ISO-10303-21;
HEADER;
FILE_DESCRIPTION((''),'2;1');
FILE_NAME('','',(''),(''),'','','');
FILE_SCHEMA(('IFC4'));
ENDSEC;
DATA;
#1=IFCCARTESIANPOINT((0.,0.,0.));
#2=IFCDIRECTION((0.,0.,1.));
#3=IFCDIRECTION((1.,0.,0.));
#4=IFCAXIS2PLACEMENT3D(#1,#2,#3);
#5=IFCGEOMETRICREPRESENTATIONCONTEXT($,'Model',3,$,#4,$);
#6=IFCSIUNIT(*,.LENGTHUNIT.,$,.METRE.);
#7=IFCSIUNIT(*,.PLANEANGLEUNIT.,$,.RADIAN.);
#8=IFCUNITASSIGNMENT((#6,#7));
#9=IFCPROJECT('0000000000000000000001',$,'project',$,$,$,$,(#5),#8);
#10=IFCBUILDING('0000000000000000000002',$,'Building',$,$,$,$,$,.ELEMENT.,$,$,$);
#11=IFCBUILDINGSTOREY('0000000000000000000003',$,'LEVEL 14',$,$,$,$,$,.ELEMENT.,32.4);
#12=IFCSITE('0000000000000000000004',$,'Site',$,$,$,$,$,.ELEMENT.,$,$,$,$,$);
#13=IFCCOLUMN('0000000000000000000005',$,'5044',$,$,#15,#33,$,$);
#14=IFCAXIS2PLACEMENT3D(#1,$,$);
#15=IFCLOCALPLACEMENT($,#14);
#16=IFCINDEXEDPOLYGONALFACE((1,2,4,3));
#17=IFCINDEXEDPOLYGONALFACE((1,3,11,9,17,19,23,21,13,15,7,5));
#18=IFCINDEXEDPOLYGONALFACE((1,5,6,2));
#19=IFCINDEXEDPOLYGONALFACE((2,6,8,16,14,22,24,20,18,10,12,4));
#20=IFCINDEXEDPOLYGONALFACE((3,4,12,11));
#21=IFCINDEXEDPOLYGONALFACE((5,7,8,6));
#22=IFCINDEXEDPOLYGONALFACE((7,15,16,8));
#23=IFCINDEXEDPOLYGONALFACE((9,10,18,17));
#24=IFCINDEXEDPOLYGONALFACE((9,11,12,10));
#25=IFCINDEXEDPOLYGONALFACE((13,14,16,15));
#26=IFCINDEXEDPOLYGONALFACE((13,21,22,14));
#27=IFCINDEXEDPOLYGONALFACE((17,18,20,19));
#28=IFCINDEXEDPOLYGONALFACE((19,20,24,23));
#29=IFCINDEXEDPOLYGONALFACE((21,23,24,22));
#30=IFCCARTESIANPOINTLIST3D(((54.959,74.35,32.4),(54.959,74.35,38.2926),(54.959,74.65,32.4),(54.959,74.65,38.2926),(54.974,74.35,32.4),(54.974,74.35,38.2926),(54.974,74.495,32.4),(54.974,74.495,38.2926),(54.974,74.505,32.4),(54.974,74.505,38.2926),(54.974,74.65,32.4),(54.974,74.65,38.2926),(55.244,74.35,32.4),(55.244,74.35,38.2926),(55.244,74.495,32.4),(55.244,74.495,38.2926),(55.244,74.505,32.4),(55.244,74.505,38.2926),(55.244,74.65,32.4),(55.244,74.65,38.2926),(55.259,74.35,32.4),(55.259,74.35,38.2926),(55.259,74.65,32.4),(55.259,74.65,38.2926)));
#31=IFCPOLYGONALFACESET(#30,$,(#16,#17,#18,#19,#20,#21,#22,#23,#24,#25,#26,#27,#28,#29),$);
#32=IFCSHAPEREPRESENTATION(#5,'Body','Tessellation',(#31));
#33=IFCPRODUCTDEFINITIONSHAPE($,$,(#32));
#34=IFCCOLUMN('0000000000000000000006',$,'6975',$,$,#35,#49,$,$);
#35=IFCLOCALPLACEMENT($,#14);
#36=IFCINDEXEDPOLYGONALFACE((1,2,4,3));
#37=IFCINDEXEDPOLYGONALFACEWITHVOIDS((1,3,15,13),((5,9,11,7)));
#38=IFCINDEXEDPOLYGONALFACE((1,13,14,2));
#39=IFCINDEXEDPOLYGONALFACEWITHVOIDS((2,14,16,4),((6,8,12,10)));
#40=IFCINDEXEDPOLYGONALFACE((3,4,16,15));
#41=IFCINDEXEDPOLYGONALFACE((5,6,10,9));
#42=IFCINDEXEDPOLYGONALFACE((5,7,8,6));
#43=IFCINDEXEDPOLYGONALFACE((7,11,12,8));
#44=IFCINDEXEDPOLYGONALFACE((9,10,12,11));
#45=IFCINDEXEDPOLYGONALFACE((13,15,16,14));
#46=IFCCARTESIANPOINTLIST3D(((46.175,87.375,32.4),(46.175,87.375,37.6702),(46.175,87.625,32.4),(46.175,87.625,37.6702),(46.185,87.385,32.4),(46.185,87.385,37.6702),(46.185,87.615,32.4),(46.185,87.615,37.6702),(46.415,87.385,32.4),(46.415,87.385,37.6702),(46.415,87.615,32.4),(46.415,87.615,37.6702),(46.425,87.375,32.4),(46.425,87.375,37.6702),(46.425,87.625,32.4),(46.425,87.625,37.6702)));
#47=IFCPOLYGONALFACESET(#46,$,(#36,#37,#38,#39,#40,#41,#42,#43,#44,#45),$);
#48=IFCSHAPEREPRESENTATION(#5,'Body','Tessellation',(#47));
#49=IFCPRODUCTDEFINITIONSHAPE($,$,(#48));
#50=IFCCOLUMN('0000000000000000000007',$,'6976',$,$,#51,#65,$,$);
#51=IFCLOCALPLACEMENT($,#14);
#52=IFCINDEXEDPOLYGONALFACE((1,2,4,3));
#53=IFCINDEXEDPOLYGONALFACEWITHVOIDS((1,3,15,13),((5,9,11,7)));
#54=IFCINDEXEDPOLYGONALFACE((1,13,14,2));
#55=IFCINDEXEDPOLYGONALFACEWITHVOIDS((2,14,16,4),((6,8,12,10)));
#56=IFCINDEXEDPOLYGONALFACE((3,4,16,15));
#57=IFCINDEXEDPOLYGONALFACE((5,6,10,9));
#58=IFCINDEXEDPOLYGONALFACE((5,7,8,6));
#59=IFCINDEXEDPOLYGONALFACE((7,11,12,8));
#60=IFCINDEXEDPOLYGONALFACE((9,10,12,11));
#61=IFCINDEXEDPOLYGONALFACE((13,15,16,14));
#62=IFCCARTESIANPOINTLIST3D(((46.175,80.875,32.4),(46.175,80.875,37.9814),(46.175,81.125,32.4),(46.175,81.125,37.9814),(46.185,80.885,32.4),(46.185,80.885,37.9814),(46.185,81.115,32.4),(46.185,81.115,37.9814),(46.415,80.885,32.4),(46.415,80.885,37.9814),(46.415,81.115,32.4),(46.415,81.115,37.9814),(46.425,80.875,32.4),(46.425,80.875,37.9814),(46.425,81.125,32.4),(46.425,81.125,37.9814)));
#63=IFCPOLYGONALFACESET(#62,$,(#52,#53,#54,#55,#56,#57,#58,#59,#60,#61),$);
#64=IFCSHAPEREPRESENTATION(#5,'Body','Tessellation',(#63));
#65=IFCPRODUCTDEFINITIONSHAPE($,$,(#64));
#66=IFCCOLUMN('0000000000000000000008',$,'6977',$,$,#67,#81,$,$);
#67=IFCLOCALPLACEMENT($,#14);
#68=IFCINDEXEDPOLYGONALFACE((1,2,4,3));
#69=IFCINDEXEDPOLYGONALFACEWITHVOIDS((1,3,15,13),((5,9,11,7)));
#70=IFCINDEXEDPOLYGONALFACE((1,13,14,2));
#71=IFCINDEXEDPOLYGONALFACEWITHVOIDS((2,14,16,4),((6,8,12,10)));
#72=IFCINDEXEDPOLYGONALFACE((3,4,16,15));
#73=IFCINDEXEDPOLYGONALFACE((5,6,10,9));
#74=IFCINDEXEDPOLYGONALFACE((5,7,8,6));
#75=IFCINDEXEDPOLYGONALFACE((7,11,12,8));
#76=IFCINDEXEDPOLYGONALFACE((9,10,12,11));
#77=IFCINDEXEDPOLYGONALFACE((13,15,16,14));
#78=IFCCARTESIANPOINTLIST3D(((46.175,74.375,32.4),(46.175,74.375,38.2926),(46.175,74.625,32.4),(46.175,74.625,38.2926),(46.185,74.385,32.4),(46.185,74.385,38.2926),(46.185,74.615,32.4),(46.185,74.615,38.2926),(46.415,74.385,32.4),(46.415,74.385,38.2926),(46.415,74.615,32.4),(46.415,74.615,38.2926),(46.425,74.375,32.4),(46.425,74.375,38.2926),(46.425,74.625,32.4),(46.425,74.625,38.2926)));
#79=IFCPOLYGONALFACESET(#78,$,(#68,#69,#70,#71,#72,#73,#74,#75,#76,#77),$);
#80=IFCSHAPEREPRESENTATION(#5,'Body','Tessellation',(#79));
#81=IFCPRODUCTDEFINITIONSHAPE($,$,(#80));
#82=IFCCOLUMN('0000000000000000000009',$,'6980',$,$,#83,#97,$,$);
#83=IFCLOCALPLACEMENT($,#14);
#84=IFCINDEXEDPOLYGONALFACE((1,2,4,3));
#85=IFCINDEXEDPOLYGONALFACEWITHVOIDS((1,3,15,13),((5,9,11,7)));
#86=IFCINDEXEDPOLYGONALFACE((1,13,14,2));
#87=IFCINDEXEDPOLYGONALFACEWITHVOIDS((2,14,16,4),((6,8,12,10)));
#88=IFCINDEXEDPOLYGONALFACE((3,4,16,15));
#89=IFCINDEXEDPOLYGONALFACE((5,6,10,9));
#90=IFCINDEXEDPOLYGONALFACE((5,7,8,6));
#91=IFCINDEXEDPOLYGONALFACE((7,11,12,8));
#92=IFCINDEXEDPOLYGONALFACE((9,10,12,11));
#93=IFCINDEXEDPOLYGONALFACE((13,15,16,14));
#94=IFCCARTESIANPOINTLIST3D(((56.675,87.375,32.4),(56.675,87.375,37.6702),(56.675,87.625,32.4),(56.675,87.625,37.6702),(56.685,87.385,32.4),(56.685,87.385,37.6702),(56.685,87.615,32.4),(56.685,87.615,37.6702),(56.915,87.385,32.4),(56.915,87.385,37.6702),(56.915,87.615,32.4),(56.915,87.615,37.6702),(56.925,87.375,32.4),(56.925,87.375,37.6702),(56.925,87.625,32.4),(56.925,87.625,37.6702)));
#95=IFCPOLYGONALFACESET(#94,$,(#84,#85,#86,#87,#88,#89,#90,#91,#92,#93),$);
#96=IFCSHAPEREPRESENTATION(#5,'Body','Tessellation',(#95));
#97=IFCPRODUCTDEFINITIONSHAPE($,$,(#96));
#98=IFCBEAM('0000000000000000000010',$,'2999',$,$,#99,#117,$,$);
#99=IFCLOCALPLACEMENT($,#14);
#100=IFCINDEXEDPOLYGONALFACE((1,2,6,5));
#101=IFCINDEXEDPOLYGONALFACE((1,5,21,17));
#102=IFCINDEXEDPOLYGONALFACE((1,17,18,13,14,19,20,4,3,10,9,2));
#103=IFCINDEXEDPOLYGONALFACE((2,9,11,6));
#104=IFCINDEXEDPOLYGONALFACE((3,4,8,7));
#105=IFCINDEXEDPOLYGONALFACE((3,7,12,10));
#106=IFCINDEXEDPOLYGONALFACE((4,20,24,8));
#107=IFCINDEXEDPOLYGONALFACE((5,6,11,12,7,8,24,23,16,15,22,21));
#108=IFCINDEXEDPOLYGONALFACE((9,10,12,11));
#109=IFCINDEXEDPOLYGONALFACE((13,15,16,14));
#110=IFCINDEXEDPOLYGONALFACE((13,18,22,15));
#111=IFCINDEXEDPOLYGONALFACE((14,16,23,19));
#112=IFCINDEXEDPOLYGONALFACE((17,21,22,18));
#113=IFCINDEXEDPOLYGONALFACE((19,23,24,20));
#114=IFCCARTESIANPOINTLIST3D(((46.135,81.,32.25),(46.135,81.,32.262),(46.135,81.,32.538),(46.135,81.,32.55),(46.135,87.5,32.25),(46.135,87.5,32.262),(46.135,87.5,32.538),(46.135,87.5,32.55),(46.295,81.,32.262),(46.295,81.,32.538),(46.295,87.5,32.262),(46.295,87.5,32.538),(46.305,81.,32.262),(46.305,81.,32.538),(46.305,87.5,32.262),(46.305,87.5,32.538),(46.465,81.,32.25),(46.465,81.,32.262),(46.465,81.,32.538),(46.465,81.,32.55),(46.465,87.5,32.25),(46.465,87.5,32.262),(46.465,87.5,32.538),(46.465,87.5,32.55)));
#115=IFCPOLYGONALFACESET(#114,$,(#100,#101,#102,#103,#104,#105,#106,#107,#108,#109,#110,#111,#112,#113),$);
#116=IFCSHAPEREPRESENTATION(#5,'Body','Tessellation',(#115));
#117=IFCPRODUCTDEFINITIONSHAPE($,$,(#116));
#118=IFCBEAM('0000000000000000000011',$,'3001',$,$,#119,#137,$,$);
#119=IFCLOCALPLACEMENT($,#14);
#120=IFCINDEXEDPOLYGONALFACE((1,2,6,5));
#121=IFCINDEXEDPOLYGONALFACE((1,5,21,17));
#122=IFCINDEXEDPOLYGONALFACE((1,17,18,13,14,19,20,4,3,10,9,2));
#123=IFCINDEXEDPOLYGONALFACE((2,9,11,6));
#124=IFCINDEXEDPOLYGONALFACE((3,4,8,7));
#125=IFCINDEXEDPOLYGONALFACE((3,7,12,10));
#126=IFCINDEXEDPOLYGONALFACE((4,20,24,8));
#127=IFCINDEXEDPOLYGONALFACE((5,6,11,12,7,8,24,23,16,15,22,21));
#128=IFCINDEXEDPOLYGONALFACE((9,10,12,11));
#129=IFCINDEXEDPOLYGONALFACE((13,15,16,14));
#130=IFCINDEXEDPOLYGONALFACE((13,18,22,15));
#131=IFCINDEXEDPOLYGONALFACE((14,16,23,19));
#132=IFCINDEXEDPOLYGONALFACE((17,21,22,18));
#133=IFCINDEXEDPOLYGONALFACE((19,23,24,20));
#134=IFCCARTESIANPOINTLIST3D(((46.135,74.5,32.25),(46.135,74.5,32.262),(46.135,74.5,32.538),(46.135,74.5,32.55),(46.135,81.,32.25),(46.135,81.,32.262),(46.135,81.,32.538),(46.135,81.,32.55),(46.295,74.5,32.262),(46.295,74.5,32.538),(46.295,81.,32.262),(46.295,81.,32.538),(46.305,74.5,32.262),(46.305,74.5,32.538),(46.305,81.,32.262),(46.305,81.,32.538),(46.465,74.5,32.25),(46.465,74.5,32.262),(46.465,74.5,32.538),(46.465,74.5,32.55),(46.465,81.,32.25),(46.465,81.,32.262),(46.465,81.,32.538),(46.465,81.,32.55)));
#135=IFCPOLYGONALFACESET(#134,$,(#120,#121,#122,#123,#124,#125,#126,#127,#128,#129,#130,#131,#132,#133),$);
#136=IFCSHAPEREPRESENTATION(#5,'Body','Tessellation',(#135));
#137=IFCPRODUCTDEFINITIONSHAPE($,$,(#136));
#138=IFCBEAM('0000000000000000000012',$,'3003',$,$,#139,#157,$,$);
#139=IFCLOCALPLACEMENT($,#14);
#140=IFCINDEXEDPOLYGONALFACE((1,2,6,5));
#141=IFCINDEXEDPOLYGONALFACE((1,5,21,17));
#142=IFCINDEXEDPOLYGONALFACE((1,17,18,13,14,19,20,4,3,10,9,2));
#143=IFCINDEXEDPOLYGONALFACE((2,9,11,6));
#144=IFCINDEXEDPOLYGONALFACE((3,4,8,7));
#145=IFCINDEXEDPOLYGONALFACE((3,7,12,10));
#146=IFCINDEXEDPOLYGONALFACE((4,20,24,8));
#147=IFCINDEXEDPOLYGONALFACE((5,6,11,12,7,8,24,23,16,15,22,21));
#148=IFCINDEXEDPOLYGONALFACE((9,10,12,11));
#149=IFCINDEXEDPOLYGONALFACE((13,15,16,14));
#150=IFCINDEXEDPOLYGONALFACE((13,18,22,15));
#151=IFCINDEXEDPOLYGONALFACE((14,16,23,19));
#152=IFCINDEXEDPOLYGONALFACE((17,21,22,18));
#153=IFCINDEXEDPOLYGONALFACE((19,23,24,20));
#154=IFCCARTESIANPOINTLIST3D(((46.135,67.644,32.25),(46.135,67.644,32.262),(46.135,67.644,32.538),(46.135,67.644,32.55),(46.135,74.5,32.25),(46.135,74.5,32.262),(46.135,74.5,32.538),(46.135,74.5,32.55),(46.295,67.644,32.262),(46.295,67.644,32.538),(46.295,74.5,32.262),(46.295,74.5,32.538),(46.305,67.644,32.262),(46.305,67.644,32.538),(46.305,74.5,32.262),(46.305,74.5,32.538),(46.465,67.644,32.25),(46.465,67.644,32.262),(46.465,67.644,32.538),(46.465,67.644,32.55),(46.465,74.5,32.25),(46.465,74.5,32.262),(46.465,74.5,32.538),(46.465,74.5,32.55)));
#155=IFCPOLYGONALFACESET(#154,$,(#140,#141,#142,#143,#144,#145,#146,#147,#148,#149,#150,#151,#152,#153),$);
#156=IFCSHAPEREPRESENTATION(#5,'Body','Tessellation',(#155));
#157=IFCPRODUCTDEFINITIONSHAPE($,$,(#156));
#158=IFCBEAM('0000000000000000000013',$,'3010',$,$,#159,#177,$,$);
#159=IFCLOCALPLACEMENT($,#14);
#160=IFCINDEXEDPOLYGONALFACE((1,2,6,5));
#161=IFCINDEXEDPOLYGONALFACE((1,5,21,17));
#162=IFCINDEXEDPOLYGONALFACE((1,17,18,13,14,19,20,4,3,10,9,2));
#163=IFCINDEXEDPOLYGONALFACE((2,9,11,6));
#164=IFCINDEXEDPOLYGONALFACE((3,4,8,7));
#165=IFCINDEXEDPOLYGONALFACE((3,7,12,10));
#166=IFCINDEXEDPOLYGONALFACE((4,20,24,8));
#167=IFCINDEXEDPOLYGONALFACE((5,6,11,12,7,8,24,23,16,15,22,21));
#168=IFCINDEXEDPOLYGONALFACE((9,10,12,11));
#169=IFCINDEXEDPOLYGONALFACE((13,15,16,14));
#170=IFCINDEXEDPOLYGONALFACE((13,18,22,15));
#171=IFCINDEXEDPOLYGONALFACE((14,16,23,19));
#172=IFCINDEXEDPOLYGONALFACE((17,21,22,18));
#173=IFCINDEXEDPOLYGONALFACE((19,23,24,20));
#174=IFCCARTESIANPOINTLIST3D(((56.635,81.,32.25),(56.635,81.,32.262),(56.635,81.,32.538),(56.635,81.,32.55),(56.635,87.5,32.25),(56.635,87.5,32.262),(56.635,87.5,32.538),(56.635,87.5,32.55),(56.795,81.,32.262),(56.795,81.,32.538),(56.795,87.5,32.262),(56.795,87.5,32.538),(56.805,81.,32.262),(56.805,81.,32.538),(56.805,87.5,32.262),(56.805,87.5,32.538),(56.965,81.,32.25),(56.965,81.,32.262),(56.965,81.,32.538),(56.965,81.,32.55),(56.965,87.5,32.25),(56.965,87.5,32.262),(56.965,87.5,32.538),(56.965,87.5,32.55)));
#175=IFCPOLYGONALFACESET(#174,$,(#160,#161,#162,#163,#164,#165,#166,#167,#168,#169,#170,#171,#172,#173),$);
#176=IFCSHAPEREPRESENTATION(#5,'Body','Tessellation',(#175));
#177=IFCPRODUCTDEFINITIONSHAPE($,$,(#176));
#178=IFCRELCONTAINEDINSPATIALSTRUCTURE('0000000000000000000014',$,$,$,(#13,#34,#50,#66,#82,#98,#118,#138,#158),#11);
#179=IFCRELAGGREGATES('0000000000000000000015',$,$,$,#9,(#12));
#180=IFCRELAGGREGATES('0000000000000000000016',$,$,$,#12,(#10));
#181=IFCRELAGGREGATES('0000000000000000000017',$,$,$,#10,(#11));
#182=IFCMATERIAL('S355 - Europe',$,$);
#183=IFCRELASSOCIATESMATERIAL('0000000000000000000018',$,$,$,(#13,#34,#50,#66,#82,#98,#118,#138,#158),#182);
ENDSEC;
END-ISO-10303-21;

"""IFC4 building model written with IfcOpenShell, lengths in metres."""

from ifc_helpers import new_model, si_unit, frame, origin_with_axes, origin_2d_with_axis, place, context, project, spatial, hollow_rectangle, i_section, extrude, material, material_profile, profile_set, profile_usage, element, save


model = new_model("IFC4")

# Units and contexts
model_context = context("Model", 3, world=origin_with_axes())
ifc_project = project(units=[si_unit("LENGTHUNIT", "METRE"), si_unit("PLANEANGLEUNIT", "RADIAN")], contexts=[model_context])

# Site, building, storey
site = spatial("IfcSite", under=ifc_project, Name="Site", CompositionType="ELEMENT")
building = spatial("IfcBuilding", under=site, Name="Building", CompositionType="ELEMENT")
storey = spatial("IfcBuildingStorey", under=building, Name="LEVEL 14", CompositionType="ELEMENT", Elevation=32.4)

# Columns
ifc_material = material(Name="S355 - Europe")
ifc_material_profile_1 = material_profile(ifc_material, i_section(OverallWidth=0.3, OverallDepth=0.3, WebThickness=0.01, FlangeThickness=0.015, at=origin_2d_with_axis()))
ifc_profile_set_1 = profile_set([ifc_material_profile_1])
ifc_profile_usage_1 = profile_usage(ifc_profile_set_1, cardinal=10)
column_1_placement = place(None, frame((55.109, 74.5, 32.4), z_axis=(0.0, 0.0, 1.0), x_axis=(0.0, -1.0, 0.0)))
element("IfcColumn", 1, at=column_1_placement, inside=storey, material=ifc_profile_usage_1, Name="5044", context=model_context, shape_type="SweptSolid", body=[
    extrude(i_section(OverallWidth=0.3, OverallDepth=0.3, WebThickness=0.01, FlangeThickness=0.015, at=origin_2d_with_axis()), origin_with_axes(), (0.0, 0.0, 1.0), 5.8926),
])
ifc_material_profile_2 = material_profile(ifc_material, hollow_rectangle(XDim=0.25, YDim=0.25, WallThickness=0.01, at=origin_2d_with_axis()))
ifc_profile_set_2 = profile_set([ifc_material_profile_2])
ifc_profile_usage_2 = profile_usage(ifc_profile_set_2, cardinal=10)
column_2_placement = place(None, frame((46.3, 87.5, 32.4), z_axis=(0.0, 0.0, 1.0), x_axis=(0.0, -1.0, 0.0)))
element("IfcColumn", 2, at=column_2_placement, inside=storey, material=ifc_profile_usage_2, Name="6975", context=model_context, shape_type="SweptSolid", body=[
    extrude(hollow_rectangle(XDim=0.25, YDim=0.25, WallThickness=0.01, at=origin_2d_with_axis()), origin_with_axes(), (0.0, 0.0, 1.0), 5.2702),
])
ifc_material_profile_3 = material_profile(ifc_material, hollow_rectangle(XDim=0.25, YDim=0.25, WallThickness=0.01, at=origin_2d_with_axis()))
ifc_profile_set_3 = profile_set([ifc_material_profile_3])
ifc_profile_usage_3 = profile_usage(ifc_profile_set_3, cardinal=10)
column_3_placement = place(None, frame((46.3, 81.0, 32.4), z_axis=(0.0, 0.0, 1.0), x_axis=(0.0, -1.0, 0.0)))
element("IfcColumn", 3, at=column_3_placement, inside=storey, material=ifc_profile_usage_3, Name="6976", context=model_context, shape_type="SweptSolid", body=[
    extrude(hollow_rectangle(XDim=0.25, YDim=0.25, WallThickness=0.01, at=origin_2d_with_axis()), origin_with_axes(), (0.0, 0.0, 1.0), 5.5814),
])
ifc_material_profile_4 = material_profile(ifc_material, hollow_rectangle(XDim=0.25, YDim=0.25, WallThickness=0.01, at=origin_2d_with_axis()))
ifc_profile_set_4 = profile_set([ifc_material_profile_4])
ifc_profile_usage_4 = profile_usage(ifc_profile_set_4, cardinal=10)
column_4_placement = place(None, frame((46.3, 74.5, 32.4), z_axis=(0.0, 0.0, 1.0), x_axis=(0.0, -1.0, 0.0)))
element("IfcColumn", 4, at=column_4_placement, inside=storey, material=ifc_profile_usage_4, Name="6977", context=model_context, shape_type="SweptSolid", body=[
    extrude(hollow_rectangle(XDim=0.25, YDim=0.25, WallThickness=0.01, at=origin_2d_with_axis()), origin_with_axes(), (0.0, 0.0, 1.0), 5.8926),
])
ifc_material_profile_5 = material_profile(ifc_material, hollow_rectangle(XDim=0.25, YDim=0.25, WallThickness=0.01, at=origin_2d_with_axis()))
ifc_profile_set_5 = profile_set([ifc_material_profile_5])
ifc_profile_usage_5 = profile_usage(ifc_profile_set_5, cardinal=10)
column_5_placement = place(None, frame((56.8, 87.5, 32.4), z_axis=(0.0, 0.0, 1.0), x_axis=(0.0, -1.0, 0.0)))
element("IfcColumn", 5, at=column_5_placement, inside=storey, material=ifc_profile_usage_5, Name="6980", context=model_context, shape_type="SweptSolid", body=[
    extrude(hollow_rectangle(XDim=0.25, YDim=0.25, WallThickness=0.01, at=origin_2d_with_axis()), origin_with_axes(), (0.0, 0.0, 1.0), 5.2702),
])

# Beams
ifc_material_profile_6 = material_profile(ifc_material, i_section(OverallWidth=0.33, OverallDepth=0.3, WebThickness=0.01, FlangeThickness=0.012, at=origin_2d_with_axis()))
ifc_profile_set_6 = profile_set([ifc_material_profile_6])
ifc_profile_usage_6 = profile_usage(ifc_profile_set_6, cardinal=10)
beam_1_placement = place(None, frame((46.3, 87.5, 32.4), z_axis=(0.0, -1.0, 0.0), x_axis=(1.0, 0.0, 0.0)))
element("IfcBeam", 6, at=beam_1_placement, inside=storey, material=ifc_profile_usage_6, Name="2999", context=model_context, shape_type="SweptSolid", body=[
    extrude(i_section(OverallWidth=0.33, OverallDepth=0.3, WebThickness=0.01, FlangeThickness=0.012, at=origin_2d_with_axis()), origin_with_axes(), (0.0, 0.0, 1.0), 6.5),
])
ifc_material_profile_7 = material_profile(ifc_material, i_section(OverallWidth=0.33, OverallDepth=0.3, WebThickness=0.01, FlangeThickness=0.012, at=origin_2d_with_axis()))
ifc_profile_set_7 = profile_set([ifc_material_profile_7])
ifc_profile_usage_7 = profile_usage(ifc_profile_set_7, cardinal=10)
beam_2_placement = place(None, frame((46.3, 81.0, 32.4), z_axis=(0.0, -1.0, 0.0), x_axis=(1.0, 0.0, 0.0)))
element("IfcBeam", 7, at=beam_2_placement, inside=storey, material=ifc_profile_usage_7, Name="3001", context=model_context, shape_type="SweptSolid", body=[
    extrude(i_section(OverallWidth=0.33, OverallDepth=0.3, WebThickness=0.01, FlangeThickness=0.012, at=origin_2d_with_axis()), origin_with_axes(), (0.0, 0.0, 1.0), 6.5),
])
ifc_material_profile_8 = material_profile(ifc_material, i_section(OverallWidth=0.33, OverallDepth=0.3, WebThickness=0.01, FlangeThickness=0.012, at=origin_2d_with_axis()))
ifc_profile_set_8 = profile_set([ifc_material_profile_8])
ifc_profile_usage_8 = profile_usage(ifc_profile_set_8, cardinal=10)
beam_3_placement = place(None, frame((46.3, 74.5, 32.4), z_axis=(0.0, -1.0, 0.0), x_axis=(1.0, 0.0, 0.0)))
element("IfcBeam", 8, at=beam_3_placement, inside=storey, material=ifc_profile_usage_8, Name="3003", context=model_context, shape_type="SweptSolid", body=[
    extrude(i_section(OverallWidth=0.33, OverallDepth=0.3, WebThickness=0.01, FlangeThickness=0.012, at=origin_2d_with_axis()), origin_with_axes(), (0.0, 0.0, 1.0), 6.856),
])
ifc_material_profile_9 = material_profile(ifc_material, i_section(OverallWidth=0.33, OverallDepth=0.3, WebThickness=0.01, FlangeThickness=0.012, at=origin_2d_with_axis()))
ifc_profile_set_9 = profile_set([ifc_material_profile_9])
ifc_profile_usage_9 = profile_usage(ifc_profile_set_9, cardinal=10)
beam_4_placement = place(None, frame((56.8, 87.5, 32.4), z_axis=(0.0, -1.0, 0.0), x_axis=(1.0, 0.0, 0.0)))
element("IfcBeam", 9, at=beam_4_placement, inside=storey, material=ifc_profile_usage_9, Name="3010", context=model_context, shape_type="SweptSolid", body=[
    extrude(i_section(OverallWidth=0.33, OverallDepth=0.3, WebThickness=0.01, FlangeThickness=0.012, at=origin_2d_with_axis()), origin_with_axes(), (0.0, 0.0, 1.0), 6.5),
])

save(model, "model.ifc")
